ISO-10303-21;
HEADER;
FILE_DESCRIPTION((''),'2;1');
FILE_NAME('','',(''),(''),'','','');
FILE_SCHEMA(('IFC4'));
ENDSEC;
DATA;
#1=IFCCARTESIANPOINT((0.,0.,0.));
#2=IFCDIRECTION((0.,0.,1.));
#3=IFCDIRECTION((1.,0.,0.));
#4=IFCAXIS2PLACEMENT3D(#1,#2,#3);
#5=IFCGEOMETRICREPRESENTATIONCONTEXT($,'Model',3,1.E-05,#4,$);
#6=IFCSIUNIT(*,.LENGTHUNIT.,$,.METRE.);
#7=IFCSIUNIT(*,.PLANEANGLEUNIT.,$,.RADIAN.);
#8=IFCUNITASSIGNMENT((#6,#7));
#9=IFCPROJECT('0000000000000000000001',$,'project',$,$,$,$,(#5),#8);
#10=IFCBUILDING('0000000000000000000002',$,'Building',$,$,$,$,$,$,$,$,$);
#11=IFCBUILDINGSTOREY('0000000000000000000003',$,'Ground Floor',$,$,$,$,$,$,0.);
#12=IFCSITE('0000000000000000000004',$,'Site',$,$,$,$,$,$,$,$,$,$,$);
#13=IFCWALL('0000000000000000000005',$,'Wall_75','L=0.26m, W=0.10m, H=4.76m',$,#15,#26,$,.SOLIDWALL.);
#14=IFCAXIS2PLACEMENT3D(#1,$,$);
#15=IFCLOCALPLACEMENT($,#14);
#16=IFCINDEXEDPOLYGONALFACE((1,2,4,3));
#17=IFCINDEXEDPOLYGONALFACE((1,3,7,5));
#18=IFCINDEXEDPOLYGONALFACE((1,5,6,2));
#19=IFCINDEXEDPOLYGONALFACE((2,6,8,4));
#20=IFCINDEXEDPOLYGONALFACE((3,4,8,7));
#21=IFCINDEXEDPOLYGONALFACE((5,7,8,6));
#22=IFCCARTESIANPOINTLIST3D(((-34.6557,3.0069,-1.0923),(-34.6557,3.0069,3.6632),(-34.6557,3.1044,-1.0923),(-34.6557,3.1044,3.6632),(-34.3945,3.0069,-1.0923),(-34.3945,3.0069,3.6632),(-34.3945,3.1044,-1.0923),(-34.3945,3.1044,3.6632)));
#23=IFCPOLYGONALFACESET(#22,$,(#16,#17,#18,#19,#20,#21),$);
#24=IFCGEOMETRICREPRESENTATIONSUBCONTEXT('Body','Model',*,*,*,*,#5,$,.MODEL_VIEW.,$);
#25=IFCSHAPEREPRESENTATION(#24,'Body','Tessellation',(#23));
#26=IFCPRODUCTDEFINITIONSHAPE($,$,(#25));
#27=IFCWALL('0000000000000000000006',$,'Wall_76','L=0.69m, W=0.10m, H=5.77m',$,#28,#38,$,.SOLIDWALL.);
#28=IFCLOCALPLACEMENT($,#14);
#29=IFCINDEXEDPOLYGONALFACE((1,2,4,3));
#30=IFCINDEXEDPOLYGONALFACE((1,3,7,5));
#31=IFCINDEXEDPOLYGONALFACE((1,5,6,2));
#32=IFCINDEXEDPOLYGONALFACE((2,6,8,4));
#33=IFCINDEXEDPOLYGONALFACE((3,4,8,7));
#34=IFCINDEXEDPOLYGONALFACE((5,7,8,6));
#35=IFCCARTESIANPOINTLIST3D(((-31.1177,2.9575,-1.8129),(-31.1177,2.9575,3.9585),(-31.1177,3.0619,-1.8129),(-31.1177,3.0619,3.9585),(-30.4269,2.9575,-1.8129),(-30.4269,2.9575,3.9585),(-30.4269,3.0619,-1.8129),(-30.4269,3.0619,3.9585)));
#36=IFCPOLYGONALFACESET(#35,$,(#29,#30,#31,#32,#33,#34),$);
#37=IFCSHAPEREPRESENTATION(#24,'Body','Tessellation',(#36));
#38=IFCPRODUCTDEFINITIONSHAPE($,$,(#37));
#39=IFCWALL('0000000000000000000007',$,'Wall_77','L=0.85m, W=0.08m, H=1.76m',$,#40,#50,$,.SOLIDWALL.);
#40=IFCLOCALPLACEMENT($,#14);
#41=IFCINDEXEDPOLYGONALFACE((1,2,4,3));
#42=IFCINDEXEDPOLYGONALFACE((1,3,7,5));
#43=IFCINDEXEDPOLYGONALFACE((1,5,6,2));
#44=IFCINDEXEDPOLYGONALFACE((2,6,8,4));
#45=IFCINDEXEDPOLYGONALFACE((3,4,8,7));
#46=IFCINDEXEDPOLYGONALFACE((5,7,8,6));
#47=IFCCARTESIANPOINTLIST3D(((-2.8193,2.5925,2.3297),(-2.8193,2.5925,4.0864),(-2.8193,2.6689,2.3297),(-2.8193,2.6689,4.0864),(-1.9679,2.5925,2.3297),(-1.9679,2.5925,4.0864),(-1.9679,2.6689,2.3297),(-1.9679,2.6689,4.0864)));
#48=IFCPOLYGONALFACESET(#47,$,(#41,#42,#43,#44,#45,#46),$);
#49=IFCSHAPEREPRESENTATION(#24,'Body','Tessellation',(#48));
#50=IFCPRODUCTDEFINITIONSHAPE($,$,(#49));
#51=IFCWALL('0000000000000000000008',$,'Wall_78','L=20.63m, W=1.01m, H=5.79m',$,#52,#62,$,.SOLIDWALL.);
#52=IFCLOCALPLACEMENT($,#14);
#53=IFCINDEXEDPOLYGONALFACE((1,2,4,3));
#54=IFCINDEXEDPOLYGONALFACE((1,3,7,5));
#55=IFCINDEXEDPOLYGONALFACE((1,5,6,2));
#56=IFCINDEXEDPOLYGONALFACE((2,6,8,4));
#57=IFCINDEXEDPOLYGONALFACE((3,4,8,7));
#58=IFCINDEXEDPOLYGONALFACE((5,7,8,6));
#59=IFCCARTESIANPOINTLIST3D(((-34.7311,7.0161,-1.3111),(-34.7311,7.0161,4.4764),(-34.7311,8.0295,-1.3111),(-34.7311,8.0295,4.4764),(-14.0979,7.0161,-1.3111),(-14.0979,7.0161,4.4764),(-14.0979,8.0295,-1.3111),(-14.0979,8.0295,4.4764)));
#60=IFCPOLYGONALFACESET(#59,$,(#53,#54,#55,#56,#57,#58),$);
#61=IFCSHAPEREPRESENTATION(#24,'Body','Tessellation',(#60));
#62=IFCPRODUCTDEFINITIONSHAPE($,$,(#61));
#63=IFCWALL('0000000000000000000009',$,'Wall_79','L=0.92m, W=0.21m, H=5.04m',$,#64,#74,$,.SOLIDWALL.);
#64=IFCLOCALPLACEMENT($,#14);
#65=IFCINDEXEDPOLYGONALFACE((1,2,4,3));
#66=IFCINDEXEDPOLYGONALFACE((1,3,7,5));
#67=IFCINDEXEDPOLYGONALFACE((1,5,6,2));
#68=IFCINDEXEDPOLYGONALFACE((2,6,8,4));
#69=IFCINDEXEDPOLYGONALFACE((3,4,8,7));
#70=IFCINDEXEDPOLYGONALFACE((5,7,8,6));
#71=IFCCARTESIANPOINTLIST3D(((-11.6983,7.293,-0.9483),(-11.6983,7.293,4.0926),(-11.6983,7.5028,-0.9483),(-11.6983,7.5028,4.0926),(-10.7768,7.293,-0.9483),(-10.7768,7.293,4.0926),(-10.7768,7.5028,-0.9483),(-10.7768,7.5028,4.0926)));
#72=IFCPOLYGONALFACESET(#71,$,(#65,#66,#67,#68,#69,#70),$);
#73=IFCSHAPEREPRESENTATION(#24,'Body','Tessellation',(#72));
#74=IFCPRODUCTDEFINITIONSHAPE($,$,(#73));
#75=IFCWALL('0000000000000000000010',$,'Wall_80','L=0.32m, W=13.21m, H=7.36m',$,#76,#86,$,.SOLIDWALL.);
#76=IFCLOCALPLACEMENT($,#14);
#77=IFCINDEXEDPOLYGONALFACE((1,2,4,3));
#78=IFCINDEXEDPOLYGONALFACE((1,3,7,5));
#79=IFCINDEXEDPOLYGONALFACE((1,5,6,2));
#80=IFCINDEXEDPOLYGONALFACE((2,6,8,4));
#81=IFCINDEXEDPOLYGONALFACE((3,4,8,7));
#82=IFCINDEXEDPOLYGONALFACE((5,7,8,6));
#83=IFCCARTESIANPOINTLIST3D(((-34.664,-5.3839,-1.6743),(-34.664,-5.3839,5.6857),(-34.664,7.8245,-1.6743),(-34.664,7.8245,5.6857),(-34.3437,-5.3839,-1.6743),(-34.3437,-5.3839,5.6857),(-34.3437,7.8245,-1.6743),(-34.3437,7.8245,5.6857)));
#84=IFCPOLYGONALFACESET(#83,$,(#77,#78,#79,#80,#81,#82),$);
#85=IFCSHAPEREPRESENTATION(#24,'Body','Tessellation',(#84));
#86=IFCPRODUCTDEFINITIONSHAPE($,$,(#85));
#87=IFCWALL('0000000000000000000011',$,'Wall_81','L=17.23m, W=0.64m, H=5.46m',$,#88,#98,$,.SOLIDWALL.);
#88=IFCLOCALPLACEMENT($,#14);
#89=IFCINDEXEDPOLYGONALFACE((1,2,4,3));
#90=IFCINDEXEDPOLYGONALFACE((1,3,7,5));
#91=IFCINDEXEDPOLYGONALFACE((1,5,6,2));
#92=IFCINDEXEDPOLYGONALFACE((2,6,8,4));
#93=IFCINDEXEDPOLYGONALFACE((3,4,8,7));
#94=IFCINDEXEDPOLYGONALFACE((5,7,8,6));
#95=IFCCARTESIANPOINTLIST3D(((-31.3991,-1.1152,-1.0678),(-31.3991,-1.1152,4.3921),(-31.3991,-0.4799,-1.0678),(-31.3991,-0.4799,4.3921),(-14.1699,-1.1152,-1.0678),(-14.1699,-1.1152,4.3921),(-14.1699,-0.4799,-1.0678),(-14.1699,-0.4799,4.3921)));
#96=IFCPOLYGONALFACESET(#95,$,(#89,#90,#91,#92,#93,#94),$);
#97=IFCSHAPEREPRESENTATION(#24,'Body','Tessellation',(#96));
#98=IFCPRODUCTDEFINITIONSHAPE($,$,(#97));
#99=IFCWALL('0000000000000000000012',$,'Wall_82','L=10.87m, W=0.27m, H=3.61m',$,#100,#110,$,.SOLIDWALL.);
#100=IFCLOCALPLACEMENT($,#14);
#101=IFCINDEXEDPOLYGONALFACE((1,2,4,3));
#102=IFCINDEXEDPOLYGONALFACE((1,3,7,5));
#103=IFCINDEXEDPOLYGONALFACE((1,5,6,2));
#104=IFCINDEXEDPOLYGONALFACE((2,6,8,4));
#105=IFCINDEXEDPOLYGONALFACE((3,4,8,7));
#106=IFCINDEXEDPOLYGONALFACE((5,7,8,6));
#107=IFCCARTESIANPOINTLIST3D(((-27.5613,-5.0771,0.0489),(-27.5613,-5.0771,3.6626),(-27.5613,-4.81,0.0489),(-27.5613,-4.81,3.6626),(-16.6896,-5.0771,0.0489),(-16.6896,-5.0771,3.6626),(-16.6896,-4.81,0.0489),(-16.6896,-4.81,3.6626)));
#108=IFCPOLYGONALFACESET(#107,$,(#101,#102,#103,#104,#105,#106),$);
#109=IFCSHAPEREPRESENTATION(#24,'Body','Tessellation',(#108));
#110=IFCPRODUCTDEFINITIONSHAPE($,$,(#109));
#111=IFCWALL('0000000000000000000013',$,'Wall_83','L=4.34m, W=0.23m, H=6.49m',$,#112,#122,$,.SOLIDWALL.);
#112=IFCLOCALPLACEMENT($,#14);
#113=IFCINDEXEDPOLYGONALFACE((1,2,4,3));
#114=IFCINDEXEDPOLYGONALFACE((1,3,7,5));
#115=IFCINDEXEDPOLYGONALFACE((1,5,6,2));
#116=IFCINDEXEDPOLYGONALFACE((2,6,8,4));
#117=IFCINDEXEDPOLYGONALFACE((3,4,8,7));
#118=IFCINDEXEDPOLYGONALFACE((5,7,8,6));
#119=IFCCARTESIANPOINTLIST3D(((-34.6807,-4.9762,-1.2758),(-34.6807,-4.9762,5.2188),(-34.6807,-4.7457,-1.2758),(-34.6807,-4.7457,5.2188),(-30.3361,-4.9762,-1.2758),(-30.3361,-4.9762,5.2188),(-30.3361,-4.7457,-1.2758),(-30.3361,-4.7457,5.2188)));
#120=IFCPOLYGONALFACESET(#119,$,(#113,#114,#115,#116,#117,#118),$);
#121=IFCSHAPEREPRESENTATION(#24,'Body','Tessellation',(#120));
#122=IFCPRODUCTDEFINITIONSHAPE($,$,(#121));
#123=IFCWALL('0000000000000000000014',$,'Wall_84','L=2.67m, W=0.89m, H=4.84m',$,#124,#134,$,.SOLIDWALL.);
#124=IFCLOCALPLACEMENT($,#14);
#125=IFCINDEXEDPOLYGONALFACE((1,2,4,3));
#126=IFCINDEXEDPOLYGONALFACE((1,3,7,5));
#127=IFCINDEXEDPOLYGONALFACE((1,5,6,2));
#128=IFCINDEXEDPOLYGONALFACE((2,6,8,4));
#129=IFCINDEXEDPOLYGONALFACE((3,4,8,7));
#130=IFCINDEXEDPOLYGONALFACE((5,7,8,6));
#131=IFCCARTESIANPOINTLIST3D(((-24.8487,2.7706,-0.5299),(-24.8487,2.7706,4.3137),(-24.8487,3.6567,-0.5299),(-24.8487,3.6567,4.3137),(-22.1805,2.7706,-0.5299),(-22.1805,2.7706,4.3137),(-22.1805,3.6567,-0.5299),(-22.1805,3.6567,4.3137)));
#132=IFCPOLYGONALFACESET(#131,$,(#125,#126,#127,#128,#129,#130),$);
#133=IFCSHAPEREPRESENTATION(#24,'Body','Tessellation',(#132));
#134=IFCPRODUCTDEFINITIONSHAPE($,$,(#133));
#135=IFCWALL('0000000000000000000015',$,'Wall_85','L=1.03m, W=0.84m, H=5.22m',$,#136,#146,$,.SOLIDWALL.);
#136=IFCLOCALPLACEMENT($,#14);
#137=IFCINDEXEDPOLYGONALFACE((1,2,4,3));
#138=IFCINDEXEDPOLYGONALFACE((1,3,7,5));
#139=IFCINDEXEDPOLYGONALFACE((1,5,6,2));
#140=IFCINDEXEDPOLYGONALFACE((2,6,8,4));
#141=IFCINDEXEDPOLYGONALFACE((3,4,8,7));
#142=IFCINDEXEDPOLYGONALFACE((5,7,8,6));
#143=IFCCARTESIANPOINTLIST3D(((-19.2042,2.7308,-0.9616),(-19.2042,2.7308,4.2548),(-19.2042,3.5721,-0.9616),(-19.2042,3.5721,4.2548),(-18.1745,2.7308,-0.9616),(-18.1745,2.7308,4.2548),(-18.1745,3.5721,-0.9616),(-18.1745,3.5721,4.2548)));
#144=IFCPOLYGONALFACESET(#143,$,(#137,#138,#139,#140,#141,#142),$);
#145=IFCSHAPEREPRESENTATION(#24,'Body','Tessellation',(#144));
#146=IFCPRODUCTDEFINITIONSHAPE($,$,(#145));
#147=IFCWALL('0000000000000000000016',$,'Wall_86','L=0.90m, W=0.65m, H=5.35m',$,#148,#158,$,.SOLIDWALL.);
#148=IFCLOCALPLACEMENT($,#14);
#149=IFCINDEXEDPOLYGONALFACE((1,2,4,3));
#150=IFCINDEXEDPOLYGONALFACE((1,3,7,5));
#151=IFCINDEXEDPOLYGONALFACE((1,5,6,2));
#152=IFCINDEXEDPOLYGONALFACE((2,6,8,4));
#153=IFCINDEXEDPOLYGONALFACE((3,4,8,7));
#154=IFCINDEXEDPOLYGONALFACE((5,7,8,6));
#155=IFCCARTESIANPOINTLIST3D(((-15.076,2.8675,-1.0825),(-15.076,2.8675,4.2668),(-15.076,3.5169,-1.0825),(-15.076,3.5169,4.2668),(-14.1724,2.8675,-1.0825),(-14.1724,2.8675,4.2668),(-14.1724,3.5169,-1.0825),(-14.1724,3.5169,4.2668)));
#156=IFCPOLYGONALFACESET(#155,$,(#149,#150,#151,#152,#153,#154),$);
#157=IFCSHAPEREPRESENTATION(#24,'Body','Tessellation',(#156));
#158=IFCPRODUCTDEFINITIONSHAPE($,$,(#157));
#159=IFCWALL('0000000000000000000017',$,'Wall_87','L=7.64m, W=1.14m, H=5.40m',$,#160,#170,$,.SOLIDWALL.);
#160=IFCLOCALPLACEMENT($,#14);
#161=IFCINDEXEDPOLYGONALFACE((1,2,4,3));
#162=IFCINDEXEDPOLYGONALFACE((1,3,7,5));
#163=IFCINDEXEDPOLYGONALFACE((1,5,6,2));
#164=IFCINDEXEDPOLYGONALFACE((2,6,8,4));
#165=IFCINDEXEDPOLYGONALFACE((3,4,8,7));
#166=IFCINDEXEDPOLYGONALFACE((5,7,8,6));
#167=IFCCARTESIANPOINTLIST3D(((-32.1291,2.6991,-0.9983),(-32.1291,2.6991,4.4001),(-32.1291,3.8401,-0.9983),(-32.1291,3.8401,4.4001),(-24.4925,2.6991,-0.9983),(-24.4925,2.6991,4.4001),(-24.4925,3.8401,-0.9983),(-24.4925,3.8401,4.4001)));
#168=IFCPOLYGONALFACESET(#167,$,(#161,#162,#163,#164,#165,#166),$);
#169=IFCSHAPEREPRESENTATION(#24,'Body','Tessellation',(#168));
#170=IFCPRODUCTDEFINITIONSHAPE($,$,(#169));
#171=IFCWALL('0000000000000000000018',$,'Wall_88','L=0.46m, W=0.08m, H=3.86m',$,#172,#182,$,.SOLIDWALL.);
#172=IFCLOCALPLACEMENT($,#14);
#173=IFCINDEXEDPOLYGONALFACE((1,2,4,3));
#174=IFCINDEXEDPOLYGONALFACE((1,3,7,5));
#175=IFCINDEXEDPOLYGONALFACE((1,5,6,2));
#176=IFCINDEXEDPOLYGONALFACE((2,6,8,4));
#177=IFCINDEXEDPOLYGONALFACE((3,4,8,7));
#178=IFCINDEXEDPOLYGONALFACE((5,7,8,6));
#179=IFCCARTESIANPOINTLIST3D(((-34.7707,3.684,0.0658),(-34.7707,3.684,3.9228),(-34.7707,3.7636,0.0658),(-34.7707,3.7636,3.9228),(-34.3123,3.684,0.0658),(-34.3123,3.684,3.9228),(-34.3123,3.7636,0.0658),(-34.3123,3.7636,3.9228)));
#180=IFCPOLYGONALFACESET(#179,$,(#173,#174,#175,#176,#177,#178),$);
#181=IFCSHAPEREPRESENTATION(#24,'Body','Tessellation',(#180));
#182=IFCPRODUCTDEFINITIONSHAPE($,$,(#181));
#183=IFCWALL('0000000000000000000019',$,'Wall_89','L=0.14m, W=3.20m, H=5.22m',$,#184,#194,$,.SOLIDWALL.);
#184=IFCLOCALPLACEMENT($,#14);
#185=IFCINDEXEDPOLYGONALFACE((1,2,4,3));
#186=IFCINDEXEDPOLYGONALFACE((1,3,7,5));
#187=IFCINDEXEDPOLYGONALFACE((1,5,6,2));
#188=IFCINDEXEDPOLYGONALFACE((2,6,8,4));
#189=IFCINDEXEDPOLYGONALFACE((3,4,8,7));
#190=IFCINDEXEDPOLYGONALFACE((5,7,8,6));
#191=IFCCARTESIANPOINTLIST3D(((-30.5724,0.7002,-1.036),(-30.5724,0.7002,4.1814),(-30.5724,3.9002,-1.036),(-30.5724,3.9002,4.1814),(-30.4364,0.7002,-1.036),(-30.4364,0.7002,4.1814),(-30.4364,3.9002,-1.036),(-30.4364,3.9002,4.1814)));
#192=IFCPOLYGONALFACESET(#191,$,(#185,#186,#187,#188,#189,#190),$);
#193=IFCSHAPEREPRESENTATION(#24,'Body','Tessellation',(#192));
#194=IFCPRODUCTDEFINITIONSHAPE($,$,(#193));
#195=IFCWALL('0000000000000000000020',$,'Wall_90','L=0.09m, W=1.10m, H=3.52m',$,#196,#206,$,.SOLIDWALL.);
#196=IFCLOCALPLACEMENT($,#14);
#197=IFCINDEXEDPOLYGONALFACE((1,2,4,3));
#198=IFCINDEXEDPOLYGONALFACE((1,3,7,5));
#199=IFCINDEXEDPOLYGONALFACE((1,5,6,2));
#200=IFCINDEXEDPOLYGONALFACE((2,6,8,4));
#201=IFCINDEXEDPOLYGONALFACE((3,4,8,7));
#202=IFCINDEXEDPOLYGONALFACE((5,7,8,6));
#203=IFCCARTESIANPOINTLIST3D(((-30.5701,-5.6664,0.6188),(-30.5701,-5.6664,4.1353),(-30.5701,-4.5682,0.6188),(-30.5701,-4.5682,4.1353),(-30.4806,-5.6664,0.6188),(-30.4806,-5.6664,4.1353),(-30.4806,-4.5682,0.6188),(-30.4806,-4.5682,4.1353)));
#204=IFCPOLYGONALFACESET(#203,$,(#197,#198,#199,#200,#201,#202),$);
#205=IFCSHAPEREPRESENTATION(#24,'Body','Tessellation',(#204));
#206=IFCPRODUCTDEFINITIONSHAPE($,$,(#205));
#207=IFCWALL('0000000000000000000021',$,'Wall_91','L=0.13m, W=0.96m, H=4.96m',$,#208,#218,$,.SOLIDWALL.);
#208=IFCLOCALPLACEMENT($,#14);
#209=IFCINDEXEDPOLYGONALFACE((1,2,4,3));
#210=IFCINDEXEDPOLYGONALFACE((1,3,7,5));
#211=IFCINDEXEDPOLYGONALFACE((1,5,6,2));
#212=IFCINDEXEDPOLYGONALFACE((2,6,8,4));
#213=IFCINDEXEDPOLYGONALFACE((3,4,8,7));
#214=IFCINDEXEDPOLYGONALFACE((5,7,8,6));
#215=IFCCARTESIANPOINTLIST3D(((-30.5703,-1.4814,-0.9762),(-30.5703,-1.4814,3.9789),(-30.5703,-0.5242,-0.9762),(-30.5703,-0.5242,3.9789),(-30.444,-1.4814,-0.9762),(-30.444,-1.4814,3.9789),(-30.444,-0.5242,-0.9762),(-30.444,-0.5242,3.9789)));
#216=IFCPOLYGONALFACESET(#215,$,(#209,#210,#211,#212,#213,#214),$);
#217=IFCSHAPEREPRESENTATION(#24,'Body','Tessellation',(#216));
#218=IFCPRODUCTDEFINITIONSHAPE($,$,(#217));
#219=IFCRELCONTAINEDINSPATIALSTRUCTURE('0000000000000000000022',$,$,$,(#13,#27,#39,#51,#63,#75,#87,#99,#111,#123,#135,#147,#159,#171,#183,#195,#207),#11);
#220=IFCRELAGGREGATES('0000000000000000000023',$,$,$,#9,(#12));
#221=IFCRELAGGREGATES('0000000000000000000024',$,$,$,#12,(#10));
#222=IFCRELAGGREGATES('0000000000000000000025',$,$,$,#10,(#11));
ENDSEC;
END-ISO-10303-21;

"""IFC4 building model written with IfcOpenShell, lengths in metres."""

from ifc_helpers import new_model, si_unit, frame, origin_with_axes, origin_2d, context, subcontext, project, spatial, rectangle, extrude, element, save


model = new_model("IFC4")

# Units and contexts
model_context = context("Model", 3, precision=1e-05, world=origin_with_axes())
body_context = subcontext(model_context, "Body", "Model", "MODEL_VIEW")
ifc_project = project(units=[si_unit("LENGTHUNIT", "METRE"), si_unit("PLANEANGLEUNIT", "RADIAN")], contexts=[model_context])

# Site, building, storey
site = spatial("IfcSite", under=ifc_project, Name="Site")
building = spatial("IfcBuilding", under=site, Name="Building")
storey = spatial("IfcBuildingStorey", under=building, Name="Ground Floor", Elevation=0.0)

# Walls
element("IfcWall", 1, inside=storey, Name="Wall_75", Description="L=0.26m, W=0.10m, H=4.76m", PredefinedType="SOLIDWALL", context=body_context, shape_type="SweptSolid", body=[
    extrude(rectangle(XDim=0.2612, YDim=0.0975, at=origin_2d()), frame((-34.5251, 3.0556, -1.0923), z_axis=(0.0, 0.0, 1.0), x_axis=(1.0, 0.0, 0.0)), (0.0, 0.0, 1.0), 4.7555),
])
element("IfcWall", 2, inside=storey, Name="Wall_76", Description="L=0.69m, W=0.10m, H=5.77m", PredefinedType="SOLIDWALL", context=body_context, shape_type="SweptSolid", body=[
    extrude(rectangle(XDim=0.6907, YDim=0.1044, at=origin_2d()), frame((-30.7723, 3.0097, -1.8129), z_axis=(0.0, 0.0, 1.0), x_axis=(1.0, 0.0, 0.0)), (0.0, 0.0, 1.0), 5.7715),
])
element("IfcWall", 3, inside=storey, Name="Wall_77", Description="L=0.85m, W=0.08m, H=1.76m", PredefinedType="SOLIDWALL", context=body_context, shape_type="SweptSolid", body=[
    extrude(rectangle(XDim=0.8514, YDim=0.0764, at=origin_2d()), frame((-2.3936, 2.6307, 2.3297), z_axis=(0.0, 0.0, 1.0), x_axis=(1.0, 0.0, 0.0)), (0.0, 0.0, 1.0), 1.7568),
])
element("IfcWall", 4, inside=storey, Name="Wall_78", Description="L=20.63m, W=1.01m, H=5.79m", PredefinedType="SOLIDWALL", context=body_context, shape_type="SweptSolid", body=[
    extrude(rectangle(XDim=20.6332, YDim=1.0133, at=origin_2d()), frame((-24.4145, 7.5228, -1.3111), z_axis=(0.0, 0.0, 1.0), x_axis=(1.0, 0.0, 0.0)), (0.0, 0.0, 1.0), 5.7875),
])
element("IfcWall", 5, inside=storey, Name="Wall_79", Description="L=0.92m, W=0.21m, H=5.04m", PredefinedType="SOLIDWALL", context=body_context, shape_type="SweptSolid", body=[
    extrude(rectangle(XDim=0.9215, YDim=0.2097, at=origin_2d()), frame((-11.2375, 7.3979, -0.9483), z_axis=(0.0, 0.0, 1.0), x_axis=(1.0, 0.0, 0.0)), (0.0, 0.0, 1.0), 5.0409),
])
element("IfcWall", 6, inside=storey, Name="Wall_80", Description="L=0.32m, W=13.21m, H=7.36m", PredefinedType="SOLIDWALL", context=body_context, shape_type="SweptSolid", body=[
    extrude(rectangle(XDim=0.3203, YDim=13.2084, at=origin_2d()), frame((-34.5038, 1.2203, -1.6743), z_axis=(0.0, 0.0, 1.0), x_axis=(1.0, 0.0, 0.0)), (0.0, 0.0, 1.0), 7.36),
])
element("IfcWall", 7, inside=storey, Name="Wall_81", Description="L=17.23m, W=0.64m, H=5.46m", PredefinedType="SOLIDWALL", context=body_context, shape_type="SweptSolid", body=[
    extrude(rectangle(XDim=17.2292, YDim=0.6353, at=origin_2d()), frame((-22.7845, -0.7975, -1.0678), z_axis=(0.0, 0.0, 1.0), x_axis=(1.0, 0.0, 0.0)), (0.0, 0.0, 1.0), 5.4599),
])
element("IfcWall", 8, inside=storey, Name="Wall_82", Description="L=10.87m, W=0.27m, H=3.61m", PredefinedType="SOLIDWALL", context=body_context, shape_type="SweptSolid", body=[
    extrude(rectangle(XDim=10.8717, YDim=0.267, at=origin_2d()), frame((-22.1254, -4.9436, 0.0489), z_axis=(0.0, 0.0, 1.0), x_axis=(1.0, 0.0, 0.0)), (0.0, 0.0, 1.0), 3.6137),
])
element("IfcWall", 9, inside=storey, Name="Wall_83", Description="L=4.34m, W=0.23m, H=6.49m", PredefinedType="SOLIDWALL", context=body_context, shape_type="SweptSolid", body=[
    extrude(rectangle(XDim=4.3446, YDim=0.2305, at=origin_2d()), frame((-32.5084, -4.861, -1.2758), z_axis=(0.0, 0.0, 1.0), x_axis=(1.0, 0.0, 0.0)), (0.0, 0.0, 1.0), 6.4946),
])
element("IfcWall", 10, inside=storey, Name="Wall_84", Description="L=2.67m, W=0.89m, H=4.84m", PredefinedType="SOLIDWALL", context=body_context, shape_type="SweptSolid", body=[
    extrude(rectangle(XDim=2.6682, YDim=0.8861, at=origin_2d()), frame((-23.5146, 3.2136, -0.5299), z_axis=(0.0, 0.0, 1.0), x_axis=(1.0, 0.0, 0.0)), (0.0, 0.0, 1.0), 4.8436),
])
element("IfcWall", 11, inside=storey, Name="Wall_85", Description="L=1.03m, W=0.84m, H=5.22m", PredefinedType="SOLIDWALL", context=body_context, shape_type="SweptSolid", body=[
    extrude(rectangle(XDim=1.0297, YDim=0.8412, at=origin_2d()), frame((-18.6894, 3.1514, -0.9616), z_axis=(0.0, 0.0, 1.0), x_axis=(1.0, 0.0, 0.0)), (0.0, 0.0, 1.0), 5.2164),
])
element("IfcWall", 12, inside=storey, Name="Wall_86", Description="L=0.90m, W=0.65m, H=5.35m", PredefinedType="SOLIDWALL", context=body_context, shape_type="SweptSolid", body=[
    extrude(rectangle(XDim=0.9035, YDim=0.6494, at=origin_2d()), frame((-14.6242, 3.1922, -1.0825), z_axis=(0.0, 0.0, 1.0), x_axis=(1.0, 0.0, 0.0)), (0.0, 0.0, 1.0), 5.3493),
])
element("IfcWall", 13, inside=storey, Name="Wall_87", Description="L=7.64m, W=1.14m, H=5.40m", PredefinedType="SOLIDWALL", context=body_context, shape_type="SweptSolid", body=[
    extrude(rectangle(XDim=7.6367, YDim=1.1411, at=origin_2d()), frame((-28.3108, 3.2696, -0.9983), z_axis=(0.0, 0.0, 1.0), x_axis=(1.0, 0.0, 0.0)), (0.0, 0.0, 1.0), 5.3984),
])
element("IfcWall", 14, inside=storey, Name="Wall_88", Description="L=0.46m, W=0.08m, H=3.86m", PredefinedType="SOLIDWALL", context=body_context, shape_type="SweptSolid", body=[
    extrude(rectangle(XDim=0.4584, YDim=0.0796, at=origin_2d()), frame((-34.5415, 3.7238, 0.0658), z_axis=(0.0, 0.0, 1.0), x_axis=(1.0, 0.0, 0.0)), (0.0, 0.0, 1.0), 3.857),
])
element("IfcWall", 15, inside=storey, Name="Wall_89", Description="L=0.14m, W=3.20m, H=5.22m", PredefinedType="SOLIDWALL", context=body_context, shape_type="SweptSolid", body=[
    extrude(rectangle(XDim=0.136, YDim=3.2, at=origin_2d()), frame((-30.5044, 2.3002, -1.036), z_axis=(0.0, 0.0, 1.0), x_axis=(1.0, 0.0, 0.0)), (0.0, 0.0, 1.0), 5.2174),
])
element("IfcWall", 16, inside=storey, Name="Wall_90", Description="L=0.09m, W=1.10m, H=3.52m", PredefinedType="SOLIDWALL", context=body_context, shape_type="SweptSolid", body=[
    extrude(rectangle(XDim=0.0895, YDim=1.0983, at=origin_2d()), frame((-30.5254, -5.1173, 0.6188), z_axis=(0.0, 0.0, 1.0), x_axis=(1.0, 0.0, 0.0)), (0.0, 0.0, 1.0), 3.5166),
])
element("IfcWall", 17, inside=storey, Name="Wall_91", Description="L=0.13m, W=0.96m, H=4.96m", PredefinedType="SOLIDWALL", context=body_context, shape_type="SweptSolid", body=[
    extrude(rectangle(XDim=0.1263, YDim=0.9571, at=origin_2d()), frame((-30.5071, -1.0028, -0.9762), z_axis=(0.0, 0.0, 1.0), x_axis=(1.0, 0.0, 0.0)), (0.0, 0.0, 1.0), 4.9551),
])

save(model, "model.ifc")
